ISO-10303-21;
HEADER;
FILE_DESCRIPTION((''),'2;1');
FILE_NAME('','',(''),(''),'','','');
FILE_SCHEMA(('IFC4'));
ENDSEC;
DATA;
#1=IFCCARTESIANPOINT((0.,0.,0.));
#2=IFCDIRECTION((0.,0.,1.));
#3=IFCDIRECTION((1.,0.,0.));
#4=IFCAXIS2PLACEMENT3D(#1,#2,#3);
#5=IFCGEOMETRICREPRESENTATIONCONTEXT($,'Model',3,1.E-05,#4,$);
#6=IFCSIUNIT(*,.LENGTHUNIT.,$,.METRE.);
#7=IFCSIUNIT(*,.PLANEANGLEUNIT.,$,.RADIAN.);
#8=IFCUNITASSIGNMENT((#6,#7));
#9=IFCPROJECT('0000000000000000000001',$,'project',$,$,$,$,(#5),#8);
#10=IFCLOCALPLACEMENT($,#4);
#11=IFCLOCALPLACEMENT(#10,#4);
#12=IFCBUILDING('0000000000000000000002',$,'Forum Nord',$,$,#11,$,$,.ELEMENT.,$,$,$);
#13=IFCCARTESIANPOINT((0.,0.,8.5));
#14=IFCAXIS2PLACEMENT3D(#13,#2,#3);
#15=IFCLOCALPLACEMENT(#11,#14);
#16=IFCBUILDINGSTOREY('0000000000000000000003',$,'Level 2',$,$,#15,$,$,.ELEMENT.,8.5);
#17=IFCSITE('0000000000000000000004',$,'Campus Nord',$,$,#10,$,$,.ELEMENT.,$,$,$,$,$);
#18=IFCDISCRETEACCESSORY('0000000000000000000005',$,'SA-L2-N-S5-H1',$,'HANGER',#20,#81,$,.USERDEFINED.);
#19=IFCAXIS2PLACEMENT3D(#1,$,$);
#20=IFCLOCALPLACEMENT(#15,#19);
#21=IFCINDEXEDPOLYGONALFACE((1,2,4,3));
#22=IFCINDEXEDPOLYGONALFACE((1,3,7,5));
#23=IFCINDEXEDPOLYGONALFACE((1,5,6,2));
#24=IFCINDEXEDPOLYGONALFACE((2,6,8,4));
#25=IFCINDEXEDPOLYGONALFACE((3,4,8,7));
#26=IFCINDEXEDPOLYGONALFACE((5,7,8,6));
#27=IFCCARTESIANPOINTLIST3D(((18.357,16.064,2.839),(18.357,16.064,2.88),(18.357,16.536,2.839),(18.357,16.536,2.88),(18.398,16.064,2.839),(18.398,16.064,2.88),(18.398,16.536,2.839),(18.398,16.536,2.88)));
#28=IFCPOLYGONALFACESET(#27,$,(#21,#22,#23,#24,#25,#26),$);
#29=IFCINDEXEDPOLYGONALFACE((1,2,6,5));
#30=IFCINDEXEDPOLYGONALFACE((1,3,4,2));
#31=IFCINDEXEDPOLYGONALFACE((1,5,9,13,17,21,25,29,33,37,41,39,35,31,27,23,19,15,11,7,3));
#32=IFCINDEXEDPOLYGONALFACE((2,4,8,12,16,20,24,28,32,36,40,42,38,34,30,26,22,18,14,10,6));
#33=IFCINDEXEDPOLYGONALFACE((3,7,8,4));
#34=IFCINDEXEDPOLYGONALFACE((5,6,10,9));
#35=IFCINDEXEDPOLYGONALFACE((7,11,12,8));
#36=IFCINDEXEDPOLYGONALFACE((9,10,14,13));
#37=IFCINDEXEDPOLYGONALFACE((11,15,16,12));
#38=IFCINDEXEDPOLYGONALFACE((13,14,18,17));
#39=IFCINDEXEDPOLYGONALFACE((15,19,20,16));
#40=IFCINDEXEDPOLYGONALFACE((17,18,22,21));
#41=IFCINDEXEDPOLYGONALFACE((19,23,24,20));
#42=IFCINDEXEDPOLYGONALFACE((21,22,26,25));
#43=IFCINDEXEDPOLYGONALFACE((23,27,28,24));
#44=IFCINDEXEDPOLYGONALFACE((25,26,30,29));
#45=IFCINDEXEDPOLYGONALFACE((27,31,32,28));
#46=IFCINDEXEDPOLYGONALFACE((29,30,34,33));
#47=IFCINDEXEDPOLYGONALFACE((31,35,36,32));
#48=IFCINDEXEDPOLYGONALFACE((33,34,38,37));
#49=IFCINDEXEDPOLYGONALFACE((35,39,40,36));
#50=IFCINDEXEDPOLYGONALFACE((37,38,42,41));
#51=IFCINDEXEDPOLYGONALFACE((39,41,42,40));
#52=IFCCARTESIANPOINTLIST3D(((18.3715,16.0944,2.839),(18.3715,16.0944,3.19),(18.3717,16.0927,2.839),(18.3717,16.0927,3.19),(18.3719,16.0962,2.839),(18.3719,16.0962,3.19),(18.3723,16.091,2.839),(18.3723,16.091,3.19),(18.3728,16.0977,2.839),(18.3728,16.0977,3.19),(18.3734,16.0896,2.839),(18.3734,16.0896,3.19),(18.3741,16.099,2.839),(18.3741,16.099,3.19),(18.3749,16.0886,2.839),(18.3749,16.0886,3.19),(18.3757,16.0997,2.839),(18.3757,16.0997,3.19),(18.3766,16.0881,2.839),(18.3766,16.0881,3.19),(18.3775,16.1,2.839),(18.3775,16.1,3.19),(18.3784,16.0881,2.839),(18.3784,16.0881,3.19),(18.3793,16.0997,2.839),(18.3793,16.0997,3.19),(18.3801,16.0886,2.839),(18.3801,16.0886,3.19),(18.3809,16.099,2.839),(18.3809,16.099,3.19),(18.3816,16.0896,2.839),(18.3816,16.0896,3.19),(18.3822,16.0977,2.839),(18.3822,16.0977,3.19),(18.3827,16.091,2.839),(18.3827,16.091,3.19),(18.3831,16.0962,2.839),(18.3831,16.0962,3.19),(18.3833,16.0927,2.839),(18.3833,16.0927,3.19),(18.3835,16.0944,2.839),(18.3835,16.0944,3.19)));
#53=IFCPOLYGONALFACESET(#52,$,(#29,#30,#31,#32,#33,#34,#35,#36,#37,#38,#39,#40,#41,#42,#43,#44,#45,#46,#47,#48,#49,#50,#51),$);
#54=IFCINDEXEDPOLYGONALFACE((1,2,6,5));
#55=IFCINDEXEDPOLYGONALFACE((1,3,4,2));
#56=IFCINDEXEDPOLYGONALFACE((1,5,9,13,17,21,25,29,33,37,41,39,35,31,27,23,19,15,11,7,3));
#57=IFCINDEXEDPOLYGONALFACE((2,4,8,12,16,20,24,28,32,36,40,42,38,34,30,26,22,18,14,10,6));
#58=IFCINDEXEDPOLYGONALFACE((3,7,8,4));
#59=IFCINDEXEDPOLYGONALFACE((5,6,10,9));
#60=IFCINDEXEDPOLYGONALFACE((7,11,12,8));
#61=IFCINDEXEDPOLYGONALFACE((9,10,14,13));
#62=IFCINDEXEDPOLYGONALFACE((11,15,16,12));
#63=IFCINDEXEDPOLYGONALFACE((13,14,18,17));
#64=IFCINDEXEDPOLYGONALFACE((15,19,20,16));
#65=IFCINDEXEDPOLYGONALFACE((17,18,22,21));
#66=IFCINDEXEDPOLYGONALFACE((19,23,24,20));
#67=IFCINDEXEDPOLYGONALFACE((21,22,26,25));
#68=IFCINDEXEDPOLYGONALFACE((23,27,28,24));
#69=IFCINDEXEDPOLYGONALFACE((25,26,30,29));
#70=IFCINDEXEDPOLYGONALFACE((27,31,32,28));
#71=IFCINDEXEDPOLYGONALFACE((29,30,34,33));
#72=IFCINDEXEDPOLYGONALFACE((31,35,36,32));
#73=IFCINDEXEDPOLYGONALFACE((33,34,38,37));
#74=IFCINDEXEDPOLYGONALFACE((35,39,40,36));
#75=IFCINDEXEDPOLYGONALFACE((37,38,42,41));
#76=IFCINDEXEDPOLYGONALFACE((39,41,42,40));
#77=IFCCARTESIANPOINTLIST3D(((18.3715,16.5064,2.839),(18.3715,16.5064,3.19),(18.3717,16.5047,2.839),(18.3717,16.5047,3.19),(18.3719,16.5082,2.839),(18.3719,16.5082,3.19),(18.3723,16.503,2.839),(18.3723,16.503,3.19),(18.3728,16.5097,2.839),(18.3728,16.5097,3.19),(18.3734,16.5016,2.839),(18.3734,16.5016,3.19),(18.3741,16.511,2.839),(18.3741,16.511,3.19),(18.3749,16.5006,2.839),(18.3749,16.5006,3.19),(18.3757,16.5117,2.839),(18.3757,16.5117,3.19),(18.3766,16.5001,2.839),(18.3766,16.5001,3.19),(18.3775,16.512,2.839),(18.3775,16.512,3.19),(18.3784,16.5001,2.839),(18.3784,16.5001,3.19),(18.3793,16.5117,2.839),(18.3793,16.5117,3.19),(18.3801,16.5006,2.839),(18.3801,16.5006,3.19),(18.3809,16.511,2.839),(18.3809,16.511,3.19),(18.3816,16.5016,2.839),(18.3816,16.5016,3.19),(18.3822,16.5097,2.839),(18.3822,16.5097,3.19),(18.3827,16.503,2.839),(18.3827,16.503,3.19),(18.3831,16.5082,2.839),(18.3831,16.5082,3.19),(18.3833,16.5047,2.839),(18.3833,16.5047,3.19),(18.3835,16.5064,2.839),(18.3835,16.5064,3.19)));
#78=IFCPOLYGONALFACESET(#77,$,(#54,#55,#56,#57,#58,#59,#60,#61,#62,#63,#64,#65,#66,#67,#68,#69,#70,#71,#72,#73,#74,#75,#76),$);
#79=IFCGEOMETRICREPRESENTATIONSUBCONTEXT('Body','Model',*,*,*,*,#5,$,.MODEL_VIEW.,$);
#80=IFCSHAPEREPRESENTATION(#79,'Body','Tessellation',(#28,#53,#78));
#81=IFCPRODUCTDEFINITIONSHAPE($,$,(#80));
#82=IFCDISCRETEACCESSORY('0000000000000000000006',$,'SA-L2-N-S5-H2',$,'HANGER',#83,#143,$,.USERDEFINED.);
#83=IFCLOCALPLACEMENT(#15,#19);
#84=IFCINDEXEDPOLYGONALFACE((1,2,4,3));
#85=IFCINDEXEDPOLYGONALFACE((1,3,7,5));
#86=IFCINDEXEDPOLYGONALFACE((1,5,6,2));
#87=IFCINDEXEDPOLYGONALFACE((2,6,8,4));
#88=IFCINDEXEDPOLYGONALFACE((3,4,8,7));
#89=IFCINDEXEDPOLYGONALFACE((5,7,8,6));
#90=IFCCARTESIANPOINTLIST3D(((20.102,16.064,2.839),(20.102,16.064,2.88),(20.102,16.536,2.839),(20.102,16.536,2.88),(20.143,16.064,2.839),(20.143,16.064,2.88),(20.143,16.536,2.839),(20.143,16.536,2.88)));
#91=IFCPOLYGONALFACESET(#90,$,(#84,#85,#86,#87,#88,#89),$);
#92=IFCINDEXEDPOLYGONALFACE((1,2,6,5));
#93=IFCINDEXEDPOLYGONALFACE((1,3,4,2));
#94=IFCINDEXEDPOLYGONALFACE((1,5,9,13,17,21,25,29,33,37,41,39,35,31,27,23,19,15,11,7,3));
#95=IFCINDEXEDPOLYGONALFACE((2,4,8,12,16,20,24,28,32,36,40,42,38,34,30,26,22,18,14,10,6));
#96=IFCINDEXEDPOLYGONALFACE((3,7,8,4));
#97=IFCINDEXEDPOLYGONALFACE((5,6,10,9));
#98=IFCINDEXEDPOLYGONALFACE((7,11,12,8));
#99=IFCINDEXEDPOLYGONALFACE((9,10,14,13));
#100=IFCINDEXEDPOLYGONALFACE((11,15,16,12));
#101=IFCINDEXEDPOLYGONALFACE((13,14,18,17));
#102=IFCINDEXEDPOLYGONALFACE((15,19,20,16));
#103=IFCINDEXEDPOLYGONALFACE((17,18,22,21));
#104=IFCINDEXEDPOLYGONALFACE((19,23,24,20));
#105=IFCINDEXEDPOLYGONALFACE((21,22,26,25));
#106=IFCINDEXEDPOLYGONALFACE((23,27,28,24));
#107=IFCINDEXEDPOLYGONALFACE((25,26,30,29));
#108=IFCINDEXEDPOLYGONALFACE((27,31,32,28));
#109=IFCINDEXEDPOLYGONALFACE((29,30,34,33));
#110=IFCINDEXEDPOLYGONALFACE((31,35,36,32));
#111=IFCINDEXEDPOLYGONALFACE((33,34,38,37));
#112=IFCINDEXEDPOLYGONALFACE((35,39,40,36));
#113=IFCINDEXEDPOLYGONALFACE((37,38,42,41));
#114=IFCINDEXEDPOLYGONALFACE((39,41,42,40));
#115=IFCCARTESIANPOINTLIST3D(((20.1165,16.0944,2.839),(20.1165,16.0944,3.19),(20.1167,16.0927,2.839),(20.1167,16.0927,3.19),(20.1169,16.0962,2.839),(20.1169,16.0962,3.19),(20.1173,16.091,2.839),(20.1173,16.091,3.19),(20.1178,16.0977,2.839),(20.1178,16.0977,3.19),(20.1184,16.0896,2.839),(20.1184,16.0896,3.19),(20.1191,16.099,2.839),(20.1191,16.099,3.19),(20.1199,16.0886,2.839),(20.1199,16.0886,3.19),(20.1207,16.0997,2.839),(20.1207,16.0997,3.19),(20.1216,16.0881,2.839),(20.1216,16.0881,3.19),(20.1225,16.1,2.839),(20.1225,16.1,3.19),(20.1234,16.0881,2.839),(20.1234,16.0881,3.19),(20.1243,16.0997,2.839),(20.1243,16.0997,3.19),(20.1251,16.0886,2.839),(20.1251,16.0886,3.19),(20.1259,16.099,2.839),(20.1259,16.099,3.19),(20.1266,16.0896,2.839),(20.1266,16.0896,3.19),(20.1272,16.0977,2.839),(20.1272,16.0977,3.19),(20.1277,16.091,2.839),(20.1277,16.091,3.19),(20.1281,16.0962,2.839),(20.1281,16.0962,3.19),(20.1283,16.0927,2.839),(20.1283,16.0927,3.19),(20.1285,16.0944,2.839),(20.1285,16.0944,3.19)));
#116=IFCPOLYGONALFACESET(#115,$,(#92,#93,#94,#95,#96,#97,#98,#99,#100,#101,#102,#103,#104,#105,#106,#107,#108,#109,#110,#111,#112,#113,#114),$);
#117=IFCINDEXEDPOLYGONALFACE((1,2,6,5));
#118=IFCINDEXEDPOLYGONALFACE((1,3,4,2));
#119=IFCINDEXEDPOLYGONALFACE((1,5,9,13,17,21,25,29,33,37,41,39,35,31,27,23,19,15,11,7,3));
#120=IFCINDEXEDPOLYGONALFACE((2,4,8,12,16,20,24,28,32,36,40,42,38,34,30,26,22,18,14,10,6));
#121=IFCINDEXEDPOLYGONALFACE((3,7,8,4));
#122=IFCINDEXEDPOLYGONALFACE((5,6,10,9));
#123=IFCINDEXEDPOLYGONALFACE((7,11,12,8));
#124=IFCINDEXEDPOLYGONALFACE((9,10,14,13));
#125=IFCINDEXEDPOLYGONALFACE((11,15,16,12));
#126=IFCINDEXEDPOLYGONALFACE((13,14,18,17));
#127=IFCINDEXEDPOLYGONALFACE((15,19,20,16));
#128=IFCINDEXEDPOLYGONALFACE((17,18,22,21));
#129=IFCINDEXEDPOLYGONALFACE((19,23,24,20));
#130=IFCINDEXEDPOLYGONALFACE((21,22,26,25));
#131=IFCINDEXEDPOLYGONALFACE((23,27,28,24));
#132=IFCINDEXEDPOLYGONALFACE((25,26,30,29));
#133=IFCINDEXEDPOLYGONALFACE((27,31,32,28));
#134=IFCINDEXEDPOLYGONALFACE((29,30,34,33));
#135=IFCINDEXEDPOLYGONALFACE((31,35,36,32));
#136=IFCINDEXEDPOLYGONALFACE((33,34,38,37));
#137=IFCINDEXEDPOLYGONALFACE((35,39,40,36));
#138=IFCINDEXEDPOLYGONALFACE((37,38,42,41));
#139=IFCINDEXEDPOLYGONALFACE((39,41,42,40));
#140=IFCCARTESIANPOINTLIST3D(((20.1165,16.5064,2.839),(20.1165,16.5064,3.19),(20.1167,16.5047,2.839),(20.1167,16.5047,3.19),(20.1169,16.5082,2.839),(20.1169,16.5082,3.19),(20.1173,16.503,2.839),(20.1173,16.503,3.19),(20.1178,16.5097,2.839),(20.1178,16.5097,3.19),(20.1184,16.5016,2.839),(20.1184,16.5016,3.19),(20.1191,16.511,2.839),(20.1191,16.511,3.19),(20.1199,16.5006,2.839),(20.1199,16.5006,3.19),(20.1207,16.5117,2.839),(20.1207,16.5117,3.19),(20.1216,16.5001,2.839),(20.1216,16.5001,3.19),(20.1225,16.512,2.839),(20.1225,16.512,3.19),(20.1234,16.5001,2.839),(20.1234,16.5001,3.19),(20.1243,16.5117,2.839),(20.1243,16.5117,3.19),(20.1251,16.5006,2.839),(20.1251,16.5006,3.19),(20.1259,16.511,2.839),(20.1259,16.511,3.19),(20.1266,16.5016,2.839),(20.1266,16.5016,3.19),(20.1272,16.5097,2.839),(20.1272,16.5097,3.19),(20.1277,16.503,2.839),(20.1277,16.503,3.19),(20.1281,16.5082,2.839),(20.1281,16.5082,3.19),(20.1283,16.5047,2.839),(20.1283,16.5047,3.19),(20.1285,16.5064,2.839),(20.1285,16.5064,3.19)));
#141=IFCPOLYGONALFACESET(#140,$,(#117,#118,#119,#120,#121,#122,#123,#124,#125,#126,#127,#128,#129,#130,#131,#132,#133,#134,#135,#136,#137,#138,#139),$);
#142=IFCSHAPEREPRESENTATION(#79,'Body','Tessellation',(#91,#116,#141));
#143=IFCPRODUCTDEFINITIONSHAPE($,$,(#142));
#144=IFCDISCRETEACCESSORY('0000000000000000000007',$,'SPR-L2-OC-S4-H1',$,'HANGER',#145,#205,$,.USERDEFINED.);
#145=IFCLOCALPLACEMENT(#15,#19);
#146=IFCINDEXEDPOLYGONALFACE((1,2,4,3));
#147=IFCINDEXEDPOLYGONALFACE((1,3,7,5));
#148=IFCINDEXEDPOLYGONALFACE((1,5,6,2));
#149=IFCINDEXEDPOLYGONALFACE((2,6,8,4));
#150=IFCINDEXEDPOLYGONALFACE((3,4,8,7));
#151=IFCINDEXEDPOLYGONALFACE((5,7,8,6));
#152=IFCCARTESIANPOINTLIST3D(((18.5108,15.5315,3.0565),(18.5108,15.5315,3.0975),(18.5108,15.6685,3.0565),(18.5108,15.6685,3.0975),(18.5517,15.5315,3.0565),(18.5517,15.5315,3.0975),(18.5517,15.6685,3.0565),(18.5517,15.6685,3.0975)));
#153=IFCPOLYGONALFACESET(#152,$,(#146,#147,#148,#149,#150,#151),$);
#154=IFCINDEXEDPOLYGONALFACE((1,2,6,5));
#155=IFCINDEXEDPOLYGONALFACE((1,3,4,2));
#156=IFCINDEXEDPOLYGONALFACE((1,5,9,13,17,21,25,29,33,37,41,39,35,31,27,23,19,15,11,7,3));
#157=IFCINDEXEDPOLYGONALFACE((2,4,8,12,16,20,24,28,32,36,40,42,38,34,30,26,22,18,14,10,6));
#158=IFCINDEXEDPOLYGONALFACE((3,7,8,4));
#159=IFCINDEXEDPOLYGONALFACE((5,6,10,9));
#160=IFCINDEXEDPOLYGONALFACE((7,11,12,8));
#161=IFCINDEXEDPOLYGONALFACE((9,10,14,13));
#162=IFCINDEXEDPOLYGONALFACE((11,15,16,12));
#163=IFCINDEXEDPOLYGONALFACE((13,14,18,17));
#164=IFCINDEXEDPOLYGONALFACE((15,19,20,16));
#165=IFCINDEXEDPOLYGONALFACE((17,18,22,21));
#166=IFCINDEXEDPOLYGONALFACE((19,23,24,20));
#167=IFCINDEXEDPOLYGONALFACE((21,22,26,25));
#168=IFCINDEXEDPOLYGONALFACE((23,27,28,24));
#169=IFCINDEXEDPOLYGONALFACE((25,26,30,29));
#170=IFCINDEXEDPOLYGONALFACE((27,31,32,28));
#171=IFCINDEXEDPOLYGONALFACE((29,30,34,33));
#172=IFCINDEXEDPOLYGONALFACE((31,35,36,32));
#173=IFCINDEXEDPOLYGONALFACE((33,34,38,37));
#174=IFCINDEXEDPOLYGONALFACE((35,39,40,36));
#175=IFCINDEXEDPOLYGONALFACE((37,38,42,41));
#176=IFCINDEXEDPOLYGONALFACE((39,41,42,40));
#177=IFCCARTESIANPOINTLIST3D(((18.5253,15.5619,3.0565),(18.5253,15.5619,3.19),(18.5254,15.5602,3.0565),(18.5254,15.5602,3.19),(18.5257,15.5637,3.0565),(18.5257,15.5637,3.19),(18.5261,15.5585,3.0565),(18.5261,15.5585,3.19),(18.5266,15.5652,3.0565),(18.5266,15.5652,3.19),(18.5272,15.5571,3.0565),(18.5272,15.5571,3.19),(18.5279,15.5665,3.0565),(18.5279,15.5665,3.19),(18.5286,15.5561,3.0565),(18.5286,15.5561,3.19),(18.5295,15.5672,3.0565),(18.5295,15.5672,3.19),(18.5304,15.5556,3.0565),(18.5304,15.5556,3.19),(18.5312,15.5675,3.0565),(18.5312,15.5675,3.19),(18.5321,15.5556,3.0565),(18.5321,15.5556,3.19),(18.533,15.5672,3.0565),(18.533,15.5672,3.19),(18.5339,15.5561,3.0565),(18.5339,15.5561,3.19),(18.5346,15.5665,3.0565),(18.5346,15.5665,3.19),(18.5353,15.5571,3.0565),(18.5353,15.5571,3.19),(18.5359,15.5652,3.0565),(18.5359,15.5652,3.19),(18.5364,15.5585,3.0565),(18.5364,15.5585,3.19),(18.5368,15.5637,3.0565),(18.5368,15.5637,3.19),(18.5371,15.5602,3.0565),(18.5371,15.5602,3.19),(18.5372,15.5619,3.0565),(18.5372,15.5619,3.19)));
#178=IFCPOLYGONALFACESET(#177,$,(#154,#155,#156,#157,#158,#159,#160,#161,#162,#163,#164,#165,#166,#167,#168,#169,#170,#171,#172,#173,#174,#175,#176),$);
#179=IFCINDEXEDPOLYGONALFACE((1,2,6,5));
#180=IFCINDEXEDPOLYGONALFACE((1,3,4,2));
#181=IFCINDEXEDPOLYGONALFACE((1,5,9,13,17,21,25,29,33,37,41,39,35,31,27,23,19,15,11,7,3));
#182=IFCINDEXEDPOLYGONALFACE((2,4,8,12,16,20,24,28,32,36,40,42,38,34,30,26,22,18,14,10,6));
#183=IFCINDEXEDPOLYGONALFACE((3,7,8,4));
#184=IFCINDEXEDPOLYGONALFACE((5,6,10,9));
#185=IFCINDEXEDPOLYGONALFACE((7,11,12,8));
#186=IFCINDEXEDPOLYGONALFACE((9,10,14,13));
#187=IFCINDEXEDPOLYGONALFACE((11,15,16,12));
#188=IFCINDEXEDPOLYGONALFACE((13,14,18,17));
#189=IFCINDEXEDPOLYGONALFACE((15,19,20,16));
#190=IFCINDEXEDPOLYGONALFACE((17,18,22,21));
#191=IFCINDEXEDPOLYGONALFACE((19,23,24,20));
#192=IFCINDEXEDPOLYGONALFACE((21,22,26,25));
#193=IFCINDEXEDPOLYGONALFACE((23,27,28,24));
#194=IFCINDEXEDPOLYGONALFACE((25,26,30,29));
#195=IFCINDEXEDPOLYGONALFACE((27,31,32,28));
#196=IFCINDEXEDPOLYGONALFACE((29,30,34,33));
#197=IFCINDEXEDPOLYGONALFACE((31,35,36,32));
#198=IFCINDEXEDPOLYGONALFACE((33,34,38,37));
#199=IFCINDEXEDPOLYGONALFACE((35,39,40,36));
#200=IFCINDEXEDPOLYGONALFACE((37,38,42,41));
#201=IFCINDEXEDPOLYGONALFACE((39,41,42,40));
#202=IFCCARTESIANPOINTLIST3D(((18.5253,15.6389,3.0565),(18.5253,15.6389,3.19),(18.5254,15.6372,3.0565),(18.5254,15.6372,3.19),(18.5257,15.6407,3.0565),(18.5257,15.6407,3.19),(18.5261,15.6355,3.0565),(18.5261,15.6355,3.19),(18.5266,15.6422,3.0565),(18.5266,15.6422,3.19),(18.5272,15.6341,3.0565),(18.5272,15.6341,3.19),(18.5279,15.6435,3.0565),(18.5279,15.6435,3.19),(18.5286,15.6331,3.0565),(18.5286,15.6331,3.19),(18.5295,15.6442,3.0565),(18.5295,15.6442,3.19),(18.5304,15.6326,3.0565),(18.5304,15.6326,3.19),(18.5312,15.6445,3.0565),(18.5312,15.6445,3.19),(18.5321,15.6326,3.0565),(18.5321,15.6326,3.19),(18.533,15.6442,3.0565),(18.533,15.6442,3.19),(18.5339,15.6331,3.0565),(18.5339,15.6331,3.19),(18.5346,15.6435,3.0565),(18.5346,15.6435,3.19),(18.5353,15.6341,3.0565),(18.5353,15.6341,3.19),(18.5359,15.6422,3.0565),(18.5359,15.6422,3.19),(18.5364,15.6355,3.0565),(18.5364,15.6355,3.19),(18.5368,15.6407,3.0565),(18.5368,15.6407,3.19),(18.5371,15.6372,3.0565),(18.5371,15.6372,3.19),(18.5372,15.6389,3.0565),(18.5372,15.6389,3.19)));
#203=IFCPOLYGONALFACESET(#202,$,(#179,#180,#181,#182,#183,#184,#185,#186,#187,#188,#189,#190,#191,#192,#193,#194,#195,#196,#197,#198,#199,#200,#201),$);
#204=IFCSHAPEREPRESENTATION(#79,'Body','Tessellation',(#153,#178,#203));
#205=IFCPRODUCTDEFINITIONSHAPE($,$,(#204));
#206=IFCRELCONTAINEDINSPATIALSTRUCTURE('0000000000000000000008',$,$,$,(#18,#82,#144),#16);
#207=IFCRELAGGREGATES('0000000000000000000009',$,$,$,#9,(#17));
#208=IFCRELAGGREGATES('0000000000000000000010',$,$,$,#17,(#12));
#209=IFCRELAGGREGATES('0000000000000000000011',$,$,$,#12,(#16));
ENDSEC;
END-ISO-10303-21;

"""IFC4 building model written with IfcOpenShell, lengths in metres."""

from ifc_helpers import new_model, si_unit, frame, frame_2d, origin_with_axes, origin_2d_with_axis, place, context, subcontext, project, spatial, rectangle, circle, extrude, element, save


model = new_model("IFC4")

# Units and contexts
model_context = context("Model", 3, precision=1e-05, world=origin_with_axes())
body_context = subcontext(model_context, "Body", "Model", "MODEL_VIEW")
ifc_project = project(units=[si_unit("LENGTHUNIT", "METRE"), si_unit("PLANEANGLEUNIT", "RADIAN")], contexts=[model_context])

# Site, building, storey
site_placement = place(None, origin_with_axes())
site = spatial("IfcSite", under=ifc_project, at=site_placement, Name="Campus Nord", CompositionType="ELEMENT")
building_placement = place(site_placement, origin_with_axes())
building = spatial("IfcBuilding", under=site, at=building_placement, Name="Forum Nord", CompositionType="ELEMENT")
storey_placement = place(building_placement, frame((0.0, 0.0, 8.5), z_axis=(0.0, 0.0, 1.0), x_axis=(1.0, 0.0, 0.0)))
storey = spatial("IfcBuildingStorey", under=building, at=storey_placement, Name="Level 2", CompositionType="ELEMENT", Elevation=8.5)

# Discrete accessories
for number, where, z_axis, x_axis, name in (
    (1, (18.3775, 16.3, 2.88), (0.0, 0.0, 1.0), (0.0, 1.0, 0.0), "SA-L2-N-S5-H1"),
    (2, (20.1225, 16.3, 2.88), (0.0, 0.0, 1.0), (0.0, 1.0, 0.0), "SA-L2-N-S5-H2"),
):
    element("IfcDiscreteAccessory", number, at=place(storey_placement, frame(where, z_axis=z_axis, x_axis=x_axis)), inside=storey, Name=name, ObjectType="HANGER", PredefinedType="USERDEFINED", context=body_context, shape_type="SweptSolid", body=[
        extrude(rectangle(XDim=0.472, YDim=0.041, at=origin_2d_with_axis()), frame((0.0, 0.0, -0.041), z_axis=(0.0, 0.0, 1.0), x_axis=(1.0, 0.0, 0.0)), (0.0, 0.0, 1.0), 0.041),
        extrude(circle(Radius=0.006, at=frame_2d((-0.206, 0.0), x_axis=(1.0, 0.0))), frame((0.0, 0.0, -0.041), z_axis=(0.0, 0.0, 1.0), x_axis=(1.0, 0.0, 0.0)), (0.0, 0.0, 1.0), 0.351),
        extrude(circle(Radius=0.006, at=frame_2d((0.206, 0.0), x_axis=(1.0, 0.0))), frame((0.0, 0.0, -0.041), z_axis=(0.0, 0.0, 1.0), x_axis=(1.0, 0.0, 0.0)), (0.0, 0.0, 1.0), 0.351),
    ])
for number, where, z_axis, x_axis, name in (
    (3, (18.5312, 15.6, 3.0975), (0.0, 0.0, 1.0), (0.0, 1.0, 0.0), "SPR-L2-OC-S4-H1"),
):
    element("IfcDiscreteAccessory", number, at=place(storey_placement, frame(where, z_axis=z_axis, x_axis=x_axis)), inside=storey, Name=name, ObjectType="HANGER", PredefinedType="USERDEFINED", context=body_context, shape_type="SweptSolid", body=[
        extrude(rectangle(XDim=0.137, YDim=0.041, at=origin_2d_with_axis()), frame((0.0, 0.0, -0.041), z_axis=(0.0, 0.0, 1.0), x_axis=(1.0, 0.0, 0.0)), (0.0, 0.0, 1.0), 0.041),
        extrude(circle(Radius=0.006, at=frame_2d((-0.0385, 0.0), x_axis=(1.0, 0.0))), frame((0.0, 0.0, -0.041), z_axis=(0.0, 0.0, 1.0), x_axis=(1.0, 0.0, 0.0)), (0.0, 0.0, 1.0), 0.1335),
        extrude(circle(Radius=0.006, at=frame_2d((0.0385, 0.0), x_axis=(1.0, 0.0))), frame((0.0, 0.0, -0.041), z_axis=(0.0, 0.0, 1.0), x_axis=(1.0, 0.0, 0.0)), (0.0, 0.0, 1.0), 0.1335),
    ])

save(model, "model.ifc")
